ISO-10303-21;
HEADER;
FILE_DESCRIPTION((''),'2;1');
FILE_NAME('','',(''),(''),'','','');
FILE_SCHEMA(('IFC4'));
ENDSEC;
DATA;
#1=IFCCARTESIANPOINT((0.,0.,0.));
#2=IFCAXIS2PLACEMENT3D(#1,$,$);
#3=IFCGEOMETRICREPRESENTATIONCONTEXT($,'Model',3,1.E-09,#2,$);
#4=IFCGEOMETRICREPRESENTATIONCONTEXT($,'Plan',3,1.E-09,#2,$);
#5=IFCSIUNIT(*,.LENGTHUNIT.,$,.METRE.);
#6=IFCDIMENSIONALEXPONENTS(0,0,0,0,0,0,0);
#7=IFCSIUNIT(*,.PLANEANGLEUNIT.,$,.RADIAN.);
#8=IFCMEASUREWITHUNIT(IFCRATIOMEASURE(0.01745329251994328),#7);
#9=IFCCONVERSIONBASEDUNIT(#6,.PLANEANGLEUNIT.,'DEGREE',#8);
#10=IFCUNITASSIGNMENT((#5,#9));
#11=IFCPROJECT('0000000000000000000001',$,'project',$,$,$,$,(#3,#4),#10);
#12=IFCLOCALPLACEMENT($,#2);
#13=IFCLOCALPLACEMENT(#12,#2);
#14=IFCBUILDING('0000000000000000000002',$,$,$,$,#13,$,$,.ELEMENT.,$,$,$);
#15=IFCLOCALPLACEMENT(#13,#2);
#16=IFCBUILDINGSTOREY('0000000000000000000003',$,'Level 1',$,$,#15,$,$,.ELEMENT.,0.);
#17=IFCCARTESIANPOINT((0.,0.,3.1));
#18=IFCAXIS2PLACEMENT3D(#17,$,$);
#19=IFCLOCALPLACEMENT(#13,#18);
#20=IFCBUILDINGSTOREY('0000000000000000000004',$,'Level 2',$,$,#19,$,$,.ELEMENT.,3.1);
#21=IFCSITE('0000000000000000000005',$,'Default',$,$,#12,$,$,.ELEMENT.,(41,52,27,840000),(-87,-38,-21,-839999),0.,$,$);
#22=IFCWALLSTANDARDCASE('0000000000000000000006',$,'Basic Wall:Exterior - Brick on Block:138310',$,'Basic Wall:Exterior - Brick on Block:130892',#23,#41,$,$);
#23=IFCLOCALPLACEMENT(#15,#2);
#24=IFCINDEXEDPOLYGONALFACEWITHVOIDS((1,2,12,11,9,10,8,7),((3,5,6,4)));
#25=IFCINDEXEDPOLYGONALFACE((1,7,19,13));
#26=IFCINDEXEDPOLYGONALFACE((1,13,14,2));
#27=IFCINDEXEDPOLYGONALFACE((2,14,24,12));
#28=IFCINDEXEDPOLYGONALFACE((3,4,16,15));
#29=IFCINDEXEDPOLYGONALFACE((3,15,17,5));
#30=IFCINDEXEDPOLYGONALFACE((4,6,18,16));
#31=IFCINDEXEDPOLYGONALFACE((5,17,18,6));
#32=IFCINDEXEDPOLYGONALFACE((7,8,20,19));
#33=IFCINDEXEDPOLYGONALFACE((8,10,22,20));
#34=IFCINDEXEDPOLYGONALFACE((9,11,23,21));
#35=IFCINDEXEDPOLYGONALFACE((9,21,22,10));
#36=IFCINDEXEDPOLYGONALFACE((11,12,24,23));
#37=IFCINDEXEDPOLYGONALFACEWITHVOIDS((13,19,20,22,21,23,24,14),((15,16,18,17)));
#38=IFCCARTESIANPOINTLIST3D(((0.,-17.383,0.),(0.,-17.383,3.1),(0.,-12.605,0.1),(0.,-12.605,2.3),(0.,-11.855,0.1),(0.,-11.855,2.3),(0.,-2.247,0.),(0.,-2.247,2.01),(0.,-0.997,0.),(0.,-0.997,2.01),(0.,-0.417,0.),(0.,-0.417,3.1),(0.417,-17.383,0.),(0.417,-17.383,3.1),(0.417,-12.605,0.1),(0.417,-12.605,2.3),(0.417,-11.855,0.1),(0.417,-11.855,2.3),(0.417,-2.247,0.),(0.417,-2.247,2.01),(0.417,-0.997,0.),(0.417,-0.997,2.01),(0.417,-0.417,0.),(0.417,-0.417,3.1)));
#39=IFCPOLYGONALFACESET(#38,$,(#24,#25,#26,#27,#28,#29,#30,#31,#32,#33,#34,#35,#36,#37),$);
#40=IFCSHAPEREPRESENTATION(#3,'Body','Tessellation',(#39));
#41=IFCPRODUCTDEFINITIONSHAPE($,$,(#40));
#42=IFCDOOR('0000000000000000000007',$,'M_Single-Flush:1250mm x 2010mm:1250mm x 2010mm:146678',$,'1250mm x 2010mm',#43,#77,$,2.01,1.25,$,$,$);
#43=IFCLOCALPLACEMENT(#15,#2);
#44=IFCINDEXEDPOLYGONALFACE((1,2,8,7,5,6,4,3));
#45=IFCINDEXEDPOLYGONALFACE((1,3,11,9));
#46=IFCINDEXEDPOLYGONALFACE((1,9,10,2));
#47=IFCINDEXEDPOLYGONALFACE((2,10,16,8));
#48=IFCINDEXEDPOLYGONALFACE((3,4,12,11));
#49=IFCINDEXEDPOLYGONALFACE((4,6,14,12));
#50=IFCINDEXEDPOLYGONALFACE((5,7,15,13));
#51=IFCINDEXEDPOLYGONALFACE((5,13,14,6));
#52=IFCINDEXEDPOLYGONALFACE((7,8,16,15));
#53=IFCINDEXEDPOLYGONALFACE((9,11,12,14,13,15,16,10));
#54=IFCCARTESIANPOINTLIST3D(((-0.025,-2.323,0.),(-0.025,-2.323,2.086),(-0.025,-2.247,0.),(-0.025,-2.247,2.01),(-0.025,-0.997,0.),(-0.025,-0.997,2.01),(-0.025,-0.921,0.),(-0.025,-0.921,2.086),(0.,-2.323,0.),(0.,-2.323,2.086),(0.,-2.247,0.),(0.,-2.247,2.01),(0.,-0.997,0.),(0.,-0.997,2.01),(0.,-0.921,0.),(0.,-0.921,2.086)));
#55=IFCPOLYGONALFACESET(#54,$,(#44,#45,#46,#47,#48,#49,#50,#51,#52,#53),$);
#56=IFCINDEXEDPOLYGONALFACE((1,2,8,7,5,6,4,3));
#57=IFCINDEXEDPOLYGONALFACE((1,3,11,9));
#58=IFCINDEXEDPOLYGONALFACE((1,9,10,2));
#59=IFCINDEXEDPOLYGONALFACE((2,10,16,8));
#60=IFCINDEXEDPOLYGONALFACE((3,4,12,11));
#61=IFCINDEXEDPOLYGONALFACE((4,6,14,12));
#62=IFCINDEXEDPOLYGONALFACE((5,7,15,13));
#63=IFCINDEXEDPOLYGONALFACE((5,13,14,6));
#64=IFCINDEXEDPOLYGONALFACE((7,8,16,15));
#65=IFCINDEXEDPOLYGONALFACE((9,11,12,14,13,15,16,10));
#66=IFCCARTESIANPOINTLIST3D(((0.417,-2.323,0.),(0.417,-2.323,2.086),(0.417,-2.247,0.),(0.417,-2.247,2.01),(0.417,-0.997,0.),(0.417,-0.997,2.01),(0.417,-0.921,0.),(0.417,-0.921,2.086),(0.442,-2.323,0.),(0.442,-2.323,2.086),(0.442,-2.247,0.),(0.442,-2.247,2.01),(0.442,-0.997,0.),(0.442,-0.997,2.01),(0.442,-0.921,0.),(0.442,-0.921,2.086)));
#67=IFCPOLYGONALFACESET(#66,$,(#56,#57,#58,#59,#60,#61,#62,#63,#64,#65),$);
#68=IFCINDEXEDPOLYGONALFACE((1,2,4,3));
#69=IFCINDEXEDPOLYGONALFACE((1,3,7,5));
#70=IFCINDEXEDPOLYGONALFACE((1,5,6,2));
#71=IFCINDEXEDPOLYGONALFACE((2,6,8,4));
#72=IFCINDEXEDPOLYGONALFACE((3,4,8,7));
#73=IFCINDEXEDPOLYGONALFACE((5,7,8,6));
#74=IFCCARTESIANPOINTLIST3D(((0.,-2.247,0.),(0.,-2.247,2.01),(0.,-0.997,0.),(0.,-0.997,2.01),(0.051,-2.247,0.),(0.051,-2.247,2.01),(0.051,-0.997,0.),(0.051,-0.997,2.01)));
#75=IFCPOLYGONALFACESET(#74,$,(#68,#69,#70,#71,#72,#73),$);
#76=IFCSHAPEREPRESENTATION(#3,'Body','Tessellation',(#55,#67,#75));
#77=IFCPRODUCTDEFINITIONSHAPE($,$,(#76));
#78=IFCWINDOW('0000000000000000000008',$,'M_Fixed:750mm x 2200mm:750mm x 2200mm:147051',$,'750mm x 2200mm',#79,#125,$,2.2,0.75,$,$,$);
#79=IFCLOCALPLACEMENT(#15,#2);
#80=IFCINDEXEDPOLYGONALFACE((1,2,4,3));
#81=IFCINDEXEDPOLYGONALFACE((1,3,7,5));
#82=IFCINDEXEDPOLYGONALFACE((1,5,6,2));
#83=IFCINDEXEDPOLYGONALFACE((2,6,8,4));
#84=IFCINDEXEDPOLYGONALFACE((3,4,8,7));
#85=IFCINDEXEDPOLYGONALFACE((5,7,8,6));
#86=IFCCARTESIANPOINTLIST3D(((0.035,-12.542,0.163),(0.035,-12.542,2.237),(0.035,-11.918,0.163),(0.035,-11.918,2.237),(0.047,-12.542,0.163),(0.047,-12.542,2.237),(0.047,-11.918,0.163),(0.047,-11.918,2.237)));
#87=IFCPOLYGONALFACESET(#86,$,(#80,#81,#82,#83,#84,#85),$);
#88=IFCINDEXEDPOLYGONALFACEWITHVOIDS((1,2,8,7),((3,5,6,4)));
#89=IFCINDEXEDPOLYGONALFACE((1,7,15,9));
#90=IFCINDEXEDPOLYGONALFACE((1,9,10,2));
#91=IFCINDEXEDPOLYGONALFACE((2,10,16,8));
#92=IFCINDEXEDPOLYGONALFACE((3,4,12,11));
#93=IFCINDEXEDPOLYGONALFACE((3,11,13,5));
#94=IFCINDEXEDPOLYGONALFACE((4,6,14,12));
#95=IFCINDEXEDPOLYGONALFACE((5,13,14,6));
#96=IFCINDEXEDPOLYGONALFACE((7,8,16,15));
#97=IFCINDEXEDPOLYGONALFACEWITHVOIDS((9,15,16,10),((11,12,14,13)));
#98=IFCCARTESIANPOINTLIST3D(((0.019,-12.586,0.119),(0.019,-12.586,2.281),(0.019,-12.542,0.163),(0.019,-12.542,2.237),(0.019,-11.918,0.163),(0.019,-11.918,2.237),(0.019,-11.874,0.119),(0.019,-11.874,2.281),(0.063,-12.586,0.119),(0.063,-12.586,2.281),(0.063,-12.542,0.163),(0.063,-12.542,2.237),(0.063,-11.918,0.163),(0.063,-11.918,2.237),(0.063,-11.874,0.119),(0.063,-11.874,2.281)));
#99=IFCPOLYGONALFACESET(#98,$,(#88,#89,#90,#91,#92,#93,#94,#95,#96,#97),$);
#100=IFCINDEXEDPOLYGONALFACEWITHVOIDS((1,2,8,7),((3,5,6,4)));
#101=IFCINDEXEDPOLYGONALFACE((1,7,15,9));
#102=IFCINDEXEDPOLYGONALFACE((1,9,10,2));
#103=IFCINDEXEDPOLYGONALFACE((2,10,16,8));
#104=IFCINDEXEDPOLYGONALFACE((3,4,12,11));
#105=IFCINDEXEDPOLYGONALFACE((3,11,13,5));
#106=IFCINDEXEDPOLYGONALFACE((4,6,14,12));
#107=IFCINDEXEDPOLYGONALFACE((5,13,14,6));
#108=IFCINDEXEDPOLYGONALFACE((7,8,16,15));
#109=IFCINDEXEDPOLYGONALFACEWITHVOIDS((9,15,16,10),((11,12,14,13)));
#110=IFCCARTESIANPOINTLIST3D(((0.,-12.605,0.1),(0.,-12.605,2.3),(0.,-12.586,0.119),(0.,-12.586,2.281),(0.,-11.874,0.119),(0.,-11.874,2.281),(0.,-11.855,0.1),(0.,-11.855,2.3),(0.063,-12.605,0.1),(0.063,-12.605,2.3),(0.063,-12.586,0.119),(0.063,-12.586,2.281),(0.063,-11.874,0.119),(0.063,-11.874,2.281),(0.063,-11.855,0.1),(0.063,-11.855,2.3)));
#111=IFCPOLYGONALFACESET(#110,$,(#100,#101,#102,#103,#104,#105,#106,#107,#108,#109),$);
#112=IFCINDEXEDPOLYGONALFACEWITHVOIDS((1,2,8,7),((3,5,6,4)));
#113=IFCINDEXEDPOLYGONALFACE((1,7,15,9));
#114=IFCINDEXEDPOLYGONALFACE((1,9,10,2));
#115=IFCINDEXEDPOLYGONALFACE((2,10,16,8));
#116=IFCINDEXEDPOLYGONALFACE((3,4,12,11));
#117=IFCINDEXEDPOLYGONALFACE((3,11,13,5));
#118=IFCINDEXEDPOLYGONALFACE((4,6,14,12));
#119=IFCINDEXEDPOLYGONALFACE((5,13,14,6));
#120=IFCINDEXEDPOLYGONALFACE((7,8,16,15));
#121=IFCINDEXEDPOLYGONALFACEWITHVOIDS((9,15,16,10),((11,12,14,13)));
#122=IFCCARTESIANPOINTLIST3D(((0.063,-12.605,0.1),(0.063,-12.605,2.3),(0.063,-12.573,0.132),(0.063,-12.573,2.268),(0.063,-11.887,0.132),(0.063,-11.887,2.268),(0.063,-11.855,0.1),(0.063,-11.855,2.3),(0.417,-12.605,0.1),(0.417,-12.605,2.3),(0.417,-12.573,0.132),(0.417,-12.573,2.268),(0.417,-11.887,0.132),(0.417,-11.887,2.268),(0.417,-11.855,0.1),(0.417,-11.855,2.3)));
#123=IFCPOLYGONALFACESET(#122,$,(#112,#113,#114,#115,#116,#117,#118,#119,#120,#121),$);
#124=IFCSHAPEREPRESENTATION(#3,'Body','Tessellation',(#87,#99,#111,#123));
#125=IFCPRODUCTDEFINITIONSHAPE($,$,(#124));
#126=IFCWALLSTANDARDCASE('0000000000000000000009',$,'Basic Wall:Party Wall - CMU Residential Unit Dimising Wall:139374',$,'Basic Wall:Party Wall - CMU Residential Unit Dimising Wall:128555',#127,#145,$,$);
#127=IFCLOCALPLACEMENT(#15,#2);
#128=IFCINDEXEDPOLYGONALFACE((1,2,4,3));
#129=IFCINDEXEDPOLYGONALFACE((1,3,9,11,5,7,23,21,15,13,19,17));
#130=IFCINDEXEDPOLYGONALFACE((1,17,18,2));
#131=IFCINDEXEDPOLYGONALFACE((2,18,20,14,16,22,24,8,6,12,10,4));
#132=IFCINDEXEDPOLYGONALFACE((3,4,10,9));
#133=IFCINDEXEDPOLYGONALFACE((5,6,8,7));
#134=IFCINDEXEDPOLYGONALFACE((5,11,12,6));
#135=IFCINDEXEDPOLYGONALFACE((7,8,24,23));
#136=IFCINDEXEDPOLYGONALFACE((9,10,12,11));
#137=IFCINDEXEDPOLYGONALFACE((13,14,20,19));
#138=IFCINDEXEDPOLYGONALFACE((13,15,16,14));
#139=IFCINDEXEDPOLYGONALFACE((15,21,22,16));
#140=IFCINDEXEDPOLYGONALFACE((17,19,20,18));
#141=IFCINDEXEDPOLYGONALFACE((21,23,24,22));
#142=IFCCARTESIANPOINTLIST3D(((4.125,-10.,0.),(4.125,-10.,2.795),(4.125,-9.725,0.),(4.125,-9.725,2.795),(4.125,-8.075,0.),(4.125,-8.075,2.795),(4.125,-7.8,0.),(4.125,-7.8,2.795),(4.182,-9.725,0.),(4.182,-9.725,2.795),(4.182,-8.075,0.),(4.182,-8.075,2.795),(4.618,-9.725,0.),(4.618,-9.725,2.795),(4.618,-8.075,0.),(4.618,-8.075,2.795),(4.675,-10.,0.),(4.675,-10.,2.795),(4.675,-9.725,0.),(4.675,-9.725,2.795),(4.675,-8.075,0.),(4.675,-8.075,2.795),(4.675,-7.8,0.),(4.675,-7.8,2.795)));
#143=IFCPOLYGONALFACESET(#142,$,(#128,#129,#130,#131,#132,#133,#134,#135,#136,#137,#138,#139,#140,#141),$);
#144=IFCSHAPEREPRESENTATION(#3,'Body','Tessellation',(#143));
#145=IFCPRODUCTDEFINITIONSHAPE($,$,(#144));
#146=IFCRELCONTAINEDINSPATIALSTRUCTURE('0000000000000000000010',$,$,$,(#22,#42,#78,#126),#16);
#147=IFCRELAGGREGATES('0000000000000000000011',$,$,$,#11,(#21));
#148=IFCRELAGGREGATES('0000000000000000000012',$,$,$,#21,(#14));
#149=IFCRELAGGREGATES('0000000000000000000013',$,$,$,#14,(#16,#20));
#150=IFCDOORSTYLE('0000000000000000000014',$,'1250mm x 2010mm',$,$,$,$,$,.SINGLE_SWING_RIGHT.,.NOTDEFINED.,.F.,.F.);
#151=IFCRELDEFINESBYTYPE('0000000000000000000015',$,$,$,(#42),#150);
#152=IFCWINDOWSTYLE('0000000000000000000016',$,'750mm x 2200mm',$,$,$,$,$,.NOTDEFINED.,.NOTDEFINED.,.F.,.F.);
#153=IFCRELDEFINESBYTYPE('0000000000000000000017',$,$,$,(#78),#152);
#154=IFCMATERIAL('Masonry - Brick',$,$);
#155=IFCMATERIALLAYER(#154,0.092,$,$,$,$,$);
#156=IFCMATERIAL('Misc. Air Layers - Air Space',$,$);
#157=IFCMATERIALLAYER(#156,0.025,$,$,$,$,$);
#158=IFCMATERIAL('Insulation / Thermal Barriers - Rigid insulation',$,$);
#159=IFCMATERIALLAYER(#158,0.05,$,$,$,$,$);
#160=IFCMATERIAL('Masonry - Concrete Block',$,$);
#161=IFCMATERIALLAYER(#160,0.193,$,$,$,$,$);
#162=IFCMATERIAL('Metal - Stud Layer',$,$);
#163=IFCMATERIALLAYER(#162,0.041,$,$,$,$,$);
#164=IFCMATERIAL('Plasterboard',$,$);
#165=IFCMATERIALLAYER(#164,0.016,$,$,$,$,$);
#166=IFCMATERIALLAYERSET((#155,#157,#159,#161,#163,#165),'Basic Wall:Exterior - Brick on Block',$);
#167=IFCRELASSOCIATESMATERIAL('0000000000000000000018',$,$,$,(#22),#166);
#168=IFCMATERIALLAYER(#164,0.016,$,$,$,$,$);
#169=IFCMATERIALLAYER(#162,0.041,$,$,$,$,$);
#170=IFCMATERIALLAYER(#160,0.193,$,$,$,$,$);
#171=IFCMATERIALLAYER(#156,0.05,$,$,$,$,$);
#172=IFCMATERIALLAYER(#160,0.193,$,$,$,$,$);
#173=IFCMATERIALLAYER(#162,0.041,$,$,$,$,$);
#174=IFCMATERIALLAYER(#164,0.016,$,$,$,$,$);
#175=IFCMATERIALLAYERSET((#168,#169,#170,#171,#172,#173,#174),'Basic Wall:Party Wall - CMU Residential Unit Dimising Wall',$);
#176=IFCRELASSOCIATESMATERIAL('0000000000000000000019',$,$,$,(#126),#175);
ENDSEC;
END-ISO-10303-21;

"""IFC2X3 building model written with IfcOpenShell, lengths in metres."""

from ifc_helpers import new_model, entity, si_unit, converted_unit, frame, frame_2d, origin, origin_2d_with_axis, place, context, project, spatial, polyline, rectangle, outline, extrude, clip, bounded_halfspace, source, transform, mapped, material, layer, layer_set, layer_usage, type_object, type_shapes, element, fill, save


model = new_model("IFC2X3")

# Units and contexts
model_context = context("Model", 3, precision=1e-09, world=origin())
plan_context = context("Plan", 3, precision=1e-09, world=origin())
ifc_project = project(units=[si_unit("LENGTHUNIT", "METRE"), converted_unit("PLANEANGLEUNIT", "DEGREE", entity("IfcRatioMeasure", 0.01745329251994328), si_unit("PLANEANGLEUNIT", "RADIAN"), dimensions=[0, 0, 0, 0, 0, 0, 0])], contexts=[model_context, plan_context])

# Site, building, storey
site_placement = place(None, origin())
site = spatial("IfcSite", under=ifc_project, at=site_placement, Name="Default", CompositionType="ELEMENT", RefLatitude=(41, 52, 27, 840000), RefLongitude=(-87, -38, -21, -839999), RefElevation=0.0)
building_placement = place(site_placement, origin())
building = spatial("IfcBuilding", under=site, at=building_placement, CompositionType="ELEMENT")
storey_1_placement = place(building_placement, origin())
storey_1 = spatial("IfcBuildingStorey", under=building, at=storey_1_placement, Name="Level 1", CompositionType="ELEMENT", Elevation=0.0)

# Shared definitions
ifc_material_1 = material(Name="Masonry - Brick")
ifc_layer_1 = layer(ifc_material_1, 0.092)
ifc_material_2 = material(Name="Misc. Air Layers - Air Space")
ifc_layer_2 = layer(ifc_material_2, 0.025)
ifc_material_3 = material(Name="Insulation / Thermal Barriers - Rigid insulation")
ifc_layer_3 = layer(ifc_material_3, 0.05)
ifc_material_4 = material(Name="Masonry - Concrete Block")
ifc_layer_4 = layer(ifc_material_4, 0.193)
ifc_material_5 = material(Name="Metal - Stud Layer")
ifc_layer_5 = layer(ifc_material_5, 0.041)
ifc_material_6 = material(Name="Plasterboard")
ifc_layer_6 = layer(ifc_material_6, 0.016)
ifc_layer_set_1 = layer_set([ifc_layer_1, ifc_layer_2, ifc_layer_3, ifc_layer_4, ifc_layer_5, ifc_layer_6], Name="Basic Wall:Exterior - Brick on Block")

# Wall, openings, door, window
ifc_layer_usage_1 = layer_usage(ifc_layer_set_1, "AXIS2", "NEGATIVE", 0.2085)
wall_1_placement = place(storey_1_placement, frame((0.2085, -17.383, 0.0), z_axis=(0.0, 0.0, 1.0), x_axis=(0.0, 1.0, 0.0)))
wall_1 = element("IfcWallStandardCase", 1, at=wall_1_placement, inside=storey_1, material=ifc_layer_usage_1, Name="Basic Wall:Exterior - Brick on Block:138310", ObjectType="Basic Wall:Exterior - Brick on Block:130892", context=model_context, shape_type="SweptSolid", body=[
    extrude(rectangle(XDim=16.966, YDim=0.417, at=frame_2d((8.483, 0.0), x_axis=(-1.0, 0.0))), origin(), (0.0, 0.0, 1.0), 3.1),
])
opening_1_placement = place(wall_1_placement, frame((15.136, -0.2085, 0.0)))
opening_1 = element("IfcOpeningElement", 2, at=opening_1_placement, cuts=wall_1, ObjectType="Opening", context=model_context, shape_type="SweptSolid", body=[
    extrude(rectangle(XDim=1.25, YDim=2.01, at=frame_2d((1.005, 0.625), x_axis=(0.0, 1.0))), frame((0.0, 0.0, 0.0), z_axis=(0.0, 1.0, 0.0), x_axis=(0.0, 0.0, 1.0)), (0.0, 0.0, 1.0), 0.417),
])
opening_2_placement = place(wall_1_placement, frame((4.778, -0.2085, 0.1)))
opening_2 = element("IfcOpeningElement", 3, at=opening_2_placement, cuts=wall_1, ObjectType="Opening", context=model_context, shape_type="SweptSolid", body=[
    extrude(rectangle(XDim=2.2, YDim=0.75, at=frame_2d((1.1, 0.375), x_axis=(1.0, 0.0))), frame((0.0, 0.0, 0.0), z_axis=(0.0, 1.0, 0.0), x_axis=(0.0, 0.0, 1.0)), (0.0, 0.0, 1.0), 0.417),
])
door_style_1 = type_object("IfcDoorStyle", Name="1250mm x 2010mm", ConstructionType="NOTDEFINED", OperationType="SINGLE_SWING_RIGHT", ParameterTakesPrecedence=False, Sizeable=False)
shared_shape_1 = source(origin(), model_context, "Body", "SweptSolid", [
    extrude(outline(polyline([(-0.701, -1.062), (0.701, -1.062), (0.701, 1.024), (0.625, 1.024), (0.625, -0.986), (-0.625, -0.986), (-0.625, 1.024), (-0.701, 1.024), (-0.701, -1.062)])), frame((0.625, 0.417, 1.024), z_axis=(0.0, 1.0, 0.0), x_axis=(1.0, 0.0, 0.0)), (0.0, 0.0, 1.0), 0.025),
    extrude(outline(polyline([(-1.062, -0.701), (1.024, -0.701), (1.024, -0.625), (-0.986, -0.625), (-0.986, 0.625), (1.024, 0.625), (1.024, 0.701), (-1.062, 0.701), (-1.062, -0.701)])), frame((0.625, -0.025, 1.024), z_axis=(0.0, 1.0, 0.0), x_axis=(0.0, 0.0, -1.0)), (0.0, 0.0, 1.0), 0.025),
    extrude(rectangle(XDim=0.051, YDim=1.25, at=origin_2d_with_axis()), frame((0.625, 0.3915, 0.0), z_axis=(0.0, 0.0, 1.0), x_axis=(0.0, 1.0, 0.0)), (0.0, 0.0, 1.0), 2.01),
])
type_shapes(door_style_1, [shared_shape_1])
door_1_placement = place(opening_1_placement, origin())
door_1 = element("IfcDoor", 4, at=door_1_placement, inside=storey_1, type_object=door_style_1, Name="M_Single-Flush:1250mm x 2010mm:1250mm x 2010mm:146678", ObjectType="1250mm x 2010mm", OverallHeight=2.01, OverallWidth=1.25, context=model_context, shape_type="MappedRepresentation", body=[
    mapped(shared_shape_1, transform((0.0, 0.0, 0.0), scale=1.0)),
])
fill(opening_1, door_1)
window_style_1 = type_object("IfcWindowStyle", Name="750mm x 2200mm", ConstructionType="NOTDEFINED", OperationType="NOTDEFINED", ParameterTakesPrecedence=False, Sizeable=False)
shared_shape_2 = source(origin(), model_context, "Body", "SweptSolid", [
    extrude(rectangle(XDim=0.012, YDim=0.624, at=origin_2d_with_axis()), frame((0.375, 0.376, 0.063), z_axis=(0.0, 0.0, 1.0), x_axis=(0.0, -1.0, 0.0)), (0.0, 0.0, 1.0), 2.074),
    extrude(outline(polyline([(-0.356, -1.081), (0.356, -1.081), (0.356, 1.081), (-0.356, 1.081), (-0.356, -1.081)]), holes=[polyline([(-0.312, -1.037), (-0.312, 1.037), (0.312, 1.037), (0.312, -1.037), (-0.312, -1.037)])]), frame((0.375, 0.354, 1.1), z_axis=(0.0, 1.0, 0.0), x_axis=(1.0, 0.0, 0.0)), (0.0, 0.0, 1.0), 0.044),
    extrude(outline(polyline([(-0.375, -1.1), (0.375, -1.1), (0.375, 1.1), (-0.375, 1.1), (-0.375, -1.1)]), holes=[polyline([(-0.356, -1.081), (-0.356, 1.081), (0.356, 1.081), (0.356, -1.081), (-0.356, -1.081)])]), frame((0.375, 0.354, 1.1), z_axis=(0.0, 1.0, 0.0), x_axis=(1.0, 0.0, 0.0)), (0.0, 0.0, 1.0), 0.063),
    extrude(outline(polyline([(-0.375, -1.1), (0.375, -1.1), (0.375, 1.1), (-0.375, 1.1), (-0.375, -1.1)]), holes=[polyline([(-0.343, -1.068), (-0.343, 1.068), (0.343, 1.068), (0.343, -1.068), (-0.343, -1.068)])]), frame((0.375, 0.0, 1.1), z_axis=(0.0, 1.0, 0.0), x_axis=(1.0, 0.0, 0.0)), (0.0, 0.0, 1.0), 0.354),
])
type_shapes(window_style_1, [shared_shape_2])
window_1_placement = place(opening_2_placement, origin())
window_1 = element("IfcWindow", 5, at=window_1_placement, inside=storey_1, type_object=window_style_1, Name="M_Fixed:750mm x 2200mm:750mm x 2200mm:147051", ObjectType="750mm x 2200mm", OverallHeight=2.2, OverallWidth=0.75, context=model_context, shape_type="MappedRepresentation", body=[
    mapped(shared_shape_2, transform((0.0, 0.0, 0.0), scale=1.0)),
])
fill(opening_2, window_1)

# Wall
ifc_layer_7 = layer(ifc_material_6, 0.016)
ifc_layer_8 = layer(ifc_material_5, 0.041)
ifc_layer_9 = layer(ifc_material_4, 0.193)
ifc_layer_10 = layer(ifc_material_2, 0.05)
ifc_layer_11 = layer(ifc_material_4, 0.193)
ifc_layer_12 = layer(ifc_material_5, 0.041)
ifc_layer_13 = layer(ifc_material_6, 0.016)
ifc_layer_set_2 = layer_set([ifc_layer_7, ifc_layer_8, ifc_layer_9, ifc_layer_10, ifc_layer_11, ifc_layer_12, ifc_layer_13], Name="Basic Wall:Party Wall - CMU Residential Unit Dimising Wall")
ifc_layer_usage_2 = layer_usage(ifc_layer_set_2, "AXIS2", "NEGATIVE", 0.275)
wall_2_placement = place(storey_1_placement, frame((4.4, -10.0, 0.0), z_axis=(0.0, 0.0, 1.0), x_axis=(0.0, 1.0, 0.0)))
element("IfcWallStandardCase", 6, at=wall_2_placement, inside=storey_1, material=ifc_layer_usage_2, Name="Basic Wall:Party Wall - CMU Residential Unit Dimising Wall:139374", ObjectType="Basic Wall:Party Wall - CMU Residential Unit Dimising Wall:128555", context=model_context, shape_type="Clipping", body=[
    clip(clip(extrude(rectangle(XDim=2.2, YDim=0.55, at=frame_2d((1.1, 0.0), x_axis=(-1.0, 0.0))), origin(), (0.0, 0.0, 1.0), 2.795), bounded_halfspace(frame((1.925, 0.218, 0.0), z_axis=(0.0, -1.0, 0.0), x_axis=(1.0, 0.0, 0.0)), True, frame((1.925, 0.218, 0.0), z_axis=(0.0, -1.0, 0.0), x_axis=(1.0, 0.0, 0.0)), polyline([(0.0, 0.0), (0.0, 2.795), (-1.65, 2.795), (-1.65, 0.0), (0.0, 0.0)]))), bounded_halfspace(frame((0.275, -0.218, 0.0), z_axis=(0.0, 1.0, 0.0), x_axis=(-1.0, 0.0, 0.0)), True, frame((0.275, -0.218, 0.0), z_axis=(0.0, 1.0, 0.0), x_axis=(-1.0, 0.0, 0.0)), polyline([(0.0, 0.0), (0.0, 2.795), (-1.65, 2.795), (-1.65, 0.0), (0.0, 0.0)]))),
])

# Shared definitions
storey_2_placement = place(building_placement, frame((0.0, 0.0, 3.1)))
storey_2 = spatial("IfcBuildingStorey", under=building, at=storey_2_placement, Name="Level 2", CompositionType="ELEMENT", Elevation=3.1)

save(model, "model.ifc")
